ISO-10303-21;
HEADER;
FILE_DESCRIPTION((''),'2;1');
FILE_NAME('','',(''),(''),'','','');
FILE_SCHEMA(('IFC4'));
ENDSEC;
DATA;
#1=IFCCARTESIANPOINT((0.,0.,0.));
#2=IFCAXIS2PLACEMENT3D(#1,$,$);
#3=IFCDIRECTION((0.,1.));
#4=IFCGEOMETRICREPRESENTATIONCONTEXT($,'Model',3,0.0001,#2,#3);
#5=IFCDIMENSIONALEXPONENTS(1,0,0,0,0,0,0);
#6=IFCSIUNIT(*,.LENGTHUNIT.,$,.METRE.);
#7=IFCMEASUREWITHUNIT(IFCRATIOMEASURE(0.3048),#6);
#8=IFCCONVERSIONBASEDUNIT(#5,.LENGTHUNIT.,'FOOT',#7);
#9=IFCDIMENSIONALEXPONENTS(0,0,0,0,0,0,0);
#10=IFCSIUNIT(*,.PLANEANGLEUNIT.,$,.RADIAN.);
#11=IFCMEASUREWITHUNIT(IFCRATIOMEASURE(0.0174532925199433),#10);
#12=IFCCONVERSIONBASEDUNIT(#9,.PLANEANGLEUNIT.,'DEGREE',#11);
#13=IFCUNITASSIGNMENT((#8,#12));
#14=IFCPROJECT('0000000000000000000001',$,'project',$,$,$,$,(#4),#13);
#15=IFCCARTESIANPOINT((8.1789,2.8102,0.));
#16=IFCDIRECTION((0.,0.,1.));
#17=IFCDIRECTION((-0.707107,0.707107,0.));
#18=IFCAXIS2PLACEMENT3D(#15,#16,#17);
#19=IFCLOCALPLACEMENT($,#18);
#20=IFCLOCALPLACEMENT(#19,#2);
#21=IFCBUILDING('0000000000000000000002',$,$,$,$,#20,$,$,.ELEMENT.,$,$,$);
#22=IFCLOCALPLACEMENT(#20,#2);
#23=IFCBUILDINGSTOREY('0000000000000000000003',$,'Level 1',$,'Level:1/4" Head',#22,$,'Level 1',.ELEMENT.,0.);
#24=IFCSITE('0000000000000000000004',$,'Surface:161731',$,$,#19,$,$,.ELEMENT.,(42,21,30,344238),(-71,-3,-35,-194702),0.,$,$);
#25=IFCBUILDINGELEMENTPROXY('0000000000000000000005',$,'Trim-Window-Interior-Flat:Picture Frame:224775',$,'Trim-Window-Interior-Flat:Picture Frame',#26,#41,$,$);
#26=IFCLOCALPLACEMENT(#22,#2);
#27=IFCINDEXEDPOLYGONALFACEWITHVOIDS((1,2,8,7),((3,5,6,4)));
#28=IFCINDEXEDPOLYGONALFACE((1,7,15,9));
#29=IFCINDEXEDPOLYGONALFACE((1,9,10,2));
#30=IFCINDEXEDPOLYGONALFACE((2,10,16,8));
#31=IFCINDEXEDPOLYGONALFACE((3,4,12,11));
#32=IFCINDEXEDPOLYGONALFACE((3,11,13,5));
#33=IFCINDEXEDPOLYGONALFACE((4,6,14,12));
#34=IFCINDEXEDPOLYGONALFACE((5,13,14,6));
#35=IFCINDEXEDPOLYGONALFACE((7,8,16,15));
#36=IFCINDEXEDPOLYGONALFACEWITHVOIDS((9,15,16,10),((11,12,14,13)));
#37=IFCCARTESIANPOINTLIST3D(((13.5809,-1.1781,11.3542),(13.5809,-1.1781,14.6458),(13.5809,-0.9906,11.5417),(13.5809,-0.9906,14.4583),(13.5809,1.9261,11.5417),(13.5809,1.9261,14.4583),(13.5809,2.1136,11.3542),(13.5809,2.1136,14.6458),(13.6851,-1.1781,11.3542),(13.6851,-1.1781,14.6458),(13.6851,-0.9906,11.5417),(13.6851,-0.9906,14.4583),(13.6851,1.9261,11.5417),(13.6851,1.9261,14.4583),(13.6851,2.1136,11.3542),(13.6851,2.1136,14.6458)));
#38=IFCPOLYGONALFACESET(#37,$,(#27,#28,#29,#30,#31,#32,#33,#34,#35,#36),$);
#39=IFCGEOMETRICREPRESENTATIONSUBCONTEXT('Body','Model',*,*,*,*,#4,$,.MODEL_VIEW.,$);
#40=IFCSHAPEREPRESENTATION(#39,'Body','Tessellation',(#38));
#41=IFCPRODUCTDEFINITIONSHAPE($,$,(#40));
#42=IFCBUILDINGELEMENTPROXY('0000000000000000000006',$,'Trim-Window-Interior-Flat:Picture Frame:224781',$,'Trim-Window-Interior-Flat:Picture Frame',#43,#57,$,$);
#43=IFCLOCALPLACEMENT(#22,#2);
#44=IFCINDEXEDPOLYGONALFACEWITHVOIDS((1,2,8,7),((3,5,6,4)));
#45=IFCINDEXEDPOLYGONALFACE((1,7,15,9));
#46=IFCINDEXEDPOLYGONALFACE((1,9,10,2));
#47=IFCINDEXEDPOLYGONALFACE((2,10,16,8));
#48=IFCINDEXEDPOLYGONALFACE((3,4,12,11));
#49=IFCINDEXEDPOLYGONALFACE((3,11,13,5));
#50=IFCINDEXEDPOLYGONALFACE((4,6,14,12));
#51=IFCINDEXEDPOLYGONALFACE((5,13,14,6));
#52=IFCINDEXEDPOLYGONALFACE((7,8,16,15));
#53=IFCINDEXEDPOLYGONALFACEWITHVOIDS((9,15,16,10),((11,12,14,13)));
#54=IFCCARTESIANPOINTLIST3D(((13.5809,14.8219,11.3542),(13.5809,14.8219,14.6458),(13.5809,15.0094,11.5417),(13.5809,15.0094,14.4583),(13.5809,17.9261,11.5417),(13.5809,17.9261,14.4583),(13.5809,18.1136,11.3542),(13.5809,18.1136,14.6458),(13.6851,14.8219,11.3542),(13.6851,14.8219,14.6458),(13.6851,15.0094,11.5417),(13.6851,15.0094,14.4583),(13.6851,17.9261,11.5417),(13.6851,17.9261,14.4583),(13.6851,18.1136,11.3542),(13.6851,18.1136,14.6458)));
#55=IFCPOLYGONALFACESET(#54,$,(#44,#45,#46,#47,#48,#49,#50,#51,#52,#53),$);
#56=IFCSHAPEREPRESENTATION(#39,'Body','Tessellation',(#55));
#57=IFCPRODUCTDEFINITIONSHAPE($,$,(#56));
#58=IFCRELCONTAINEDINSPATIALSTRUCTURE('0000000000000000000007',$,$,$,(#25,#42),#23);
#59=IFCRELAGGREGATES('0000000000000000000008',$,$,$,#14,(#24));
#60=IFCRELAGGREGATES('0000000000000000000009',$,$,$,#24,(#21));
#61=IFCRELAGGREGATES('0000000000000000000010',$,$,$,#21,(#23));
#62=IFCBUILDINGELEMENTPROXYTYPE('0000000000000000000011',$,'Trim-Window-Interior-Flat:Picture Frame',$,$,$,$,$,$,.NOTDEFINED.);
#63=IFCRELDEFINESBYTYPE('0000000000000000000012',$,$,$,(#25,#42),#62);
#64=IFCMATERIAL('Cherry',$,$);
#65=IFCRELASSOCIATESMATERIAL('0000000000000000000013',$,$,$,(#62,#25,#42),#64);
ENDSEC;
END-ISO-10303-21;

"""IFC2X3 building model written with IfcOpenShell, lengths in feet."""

from ifc_helpers import new_model, entity, si_unit, converted_unit, direction, frame, origin, place, context, subcontext, project, spatial, polyline, outline, extrude, source, transform, mapped, material, type_object, type_shapes, element, save


model = new_model("IFC2X3")

# Units and contexts
model_context = context("Model", 3, precision=0.0001, world=origin(), true_north=direction((0.0, 1.0)))
body_context = subcontext(model_context, "Body", "Model", "MODEL_VIEW")
ifc_project = project(units=[converted_unit("LENGTHUNIT", "FOOT", entity("IfcRatioMeasure", 0.3048), si_unit("LENGTHUNIT", "METRE"), dimensions=[1, 0, 0, 0, 0, 0, 0]), converted_unit("PLANEANGLEUNIT", "DEGREE", entity("IfcRatioMeasure", 0.0174532925199433), si_unit("PLANEANGLEUNIT", "RADIAN"), dimensions=[0, 0, 0, 0, 0, 0, 0])], contexts=[model_context])

# Site, building, storey
site_placement = place(None, frame((8.1789, 2.8102, 0.0), z_axis=(0.0, 0.0, 1.0), x_axis=(-0.707107, 0.707107, 0.0)))
site = spatial("IfcSite", under=ifc_project, at=site_placement, Name="Surface:161731", CompositionType="ELEMENT", RefLatitude=(42, 21, 30, 344238), RefLongitude=(-71, -3, -35, -194702), RefElevation=0.0)
building_placement = place(site_placement, origin())
building = spatial("IfcBuilding", under=site, at=building_placement, CompositionType="ELEMENT")
storey_placement = place(building_placement, origin())
storey = spatial("IfcBuildingStorey", under=building, at=storey_placement, Name="Level 1", ObjectType="Level:1/4\" Head", LongName="Level 1", CompositionType="ELEMENT", Elevation=0.0)

# Building element proxies
ifc_material_1 = material(Name="Cherry")
building_element_proxy_type_1 = type_object("IfcBuildingElementProxyType", Name="Trim-Window-Interior-Flat:Picture Frame", PredefinedType="NOTDEFINED", material=ifc_material_1)
shared_shape_1 = source(origin(), body_context, "Body", "SweptSolid", [
    extrude(outline(polyline([(-1.6458, -1.6458), (1.6458, -1.6458), (1.6458, 1.6458), (-1.6458, 1.6458), (-1.6458, -1.6458)]), holes=[polyline([(-1.4583, -1.4583), (-1.4583, 1.4583), (1.4583, 1.4583), (1.4583, -1.4583), (-1.4583, -1.4583)])]), frame((0.0, 1.5, 0.0), z_axis=(0.0, 0.0, 1.0), x_axis=(0.0, 1.0, 0.0)), (0.0, 0.0, 1.0), 0.1042),
])
type_shapes(building_element_proxy_type_1, [shared_shape_1])
for number, where, z_axis, x_axis, name in (
    (1, (13.6851, 0.4677, 14.5), (-1.0, 0.0, 0.0), (0.0, 1.0, 0.0), "Trim-Window-Interior-Flat:Picture Frame:224775"),
    (2, (13.6851, 16.4677, 14.5), (-1.0, 0.0, 0.0), (0.0, 1.0, 0.0), "Trim-Window-Interior-Flat:Picture Frame:224781"),
):
    element("IfcBuildingElementProxy", number, at=place(storey_placement, frame(where, z_axis=z_axis, x_axis=x_axis)), inside=storey, type_object=building_element_proxy_type_1, material=ifc_material_1, Name=name, ObjectType="Trim-Window-Interior-Flat:Picture Frame", context=body_context, shape_type="MappedRepresentation", body=[
        mapped(shared_shape_1, transform((0.0, 0.0, 0.0), scale=1.0)),
    ])

save(model, "model.ifc")
